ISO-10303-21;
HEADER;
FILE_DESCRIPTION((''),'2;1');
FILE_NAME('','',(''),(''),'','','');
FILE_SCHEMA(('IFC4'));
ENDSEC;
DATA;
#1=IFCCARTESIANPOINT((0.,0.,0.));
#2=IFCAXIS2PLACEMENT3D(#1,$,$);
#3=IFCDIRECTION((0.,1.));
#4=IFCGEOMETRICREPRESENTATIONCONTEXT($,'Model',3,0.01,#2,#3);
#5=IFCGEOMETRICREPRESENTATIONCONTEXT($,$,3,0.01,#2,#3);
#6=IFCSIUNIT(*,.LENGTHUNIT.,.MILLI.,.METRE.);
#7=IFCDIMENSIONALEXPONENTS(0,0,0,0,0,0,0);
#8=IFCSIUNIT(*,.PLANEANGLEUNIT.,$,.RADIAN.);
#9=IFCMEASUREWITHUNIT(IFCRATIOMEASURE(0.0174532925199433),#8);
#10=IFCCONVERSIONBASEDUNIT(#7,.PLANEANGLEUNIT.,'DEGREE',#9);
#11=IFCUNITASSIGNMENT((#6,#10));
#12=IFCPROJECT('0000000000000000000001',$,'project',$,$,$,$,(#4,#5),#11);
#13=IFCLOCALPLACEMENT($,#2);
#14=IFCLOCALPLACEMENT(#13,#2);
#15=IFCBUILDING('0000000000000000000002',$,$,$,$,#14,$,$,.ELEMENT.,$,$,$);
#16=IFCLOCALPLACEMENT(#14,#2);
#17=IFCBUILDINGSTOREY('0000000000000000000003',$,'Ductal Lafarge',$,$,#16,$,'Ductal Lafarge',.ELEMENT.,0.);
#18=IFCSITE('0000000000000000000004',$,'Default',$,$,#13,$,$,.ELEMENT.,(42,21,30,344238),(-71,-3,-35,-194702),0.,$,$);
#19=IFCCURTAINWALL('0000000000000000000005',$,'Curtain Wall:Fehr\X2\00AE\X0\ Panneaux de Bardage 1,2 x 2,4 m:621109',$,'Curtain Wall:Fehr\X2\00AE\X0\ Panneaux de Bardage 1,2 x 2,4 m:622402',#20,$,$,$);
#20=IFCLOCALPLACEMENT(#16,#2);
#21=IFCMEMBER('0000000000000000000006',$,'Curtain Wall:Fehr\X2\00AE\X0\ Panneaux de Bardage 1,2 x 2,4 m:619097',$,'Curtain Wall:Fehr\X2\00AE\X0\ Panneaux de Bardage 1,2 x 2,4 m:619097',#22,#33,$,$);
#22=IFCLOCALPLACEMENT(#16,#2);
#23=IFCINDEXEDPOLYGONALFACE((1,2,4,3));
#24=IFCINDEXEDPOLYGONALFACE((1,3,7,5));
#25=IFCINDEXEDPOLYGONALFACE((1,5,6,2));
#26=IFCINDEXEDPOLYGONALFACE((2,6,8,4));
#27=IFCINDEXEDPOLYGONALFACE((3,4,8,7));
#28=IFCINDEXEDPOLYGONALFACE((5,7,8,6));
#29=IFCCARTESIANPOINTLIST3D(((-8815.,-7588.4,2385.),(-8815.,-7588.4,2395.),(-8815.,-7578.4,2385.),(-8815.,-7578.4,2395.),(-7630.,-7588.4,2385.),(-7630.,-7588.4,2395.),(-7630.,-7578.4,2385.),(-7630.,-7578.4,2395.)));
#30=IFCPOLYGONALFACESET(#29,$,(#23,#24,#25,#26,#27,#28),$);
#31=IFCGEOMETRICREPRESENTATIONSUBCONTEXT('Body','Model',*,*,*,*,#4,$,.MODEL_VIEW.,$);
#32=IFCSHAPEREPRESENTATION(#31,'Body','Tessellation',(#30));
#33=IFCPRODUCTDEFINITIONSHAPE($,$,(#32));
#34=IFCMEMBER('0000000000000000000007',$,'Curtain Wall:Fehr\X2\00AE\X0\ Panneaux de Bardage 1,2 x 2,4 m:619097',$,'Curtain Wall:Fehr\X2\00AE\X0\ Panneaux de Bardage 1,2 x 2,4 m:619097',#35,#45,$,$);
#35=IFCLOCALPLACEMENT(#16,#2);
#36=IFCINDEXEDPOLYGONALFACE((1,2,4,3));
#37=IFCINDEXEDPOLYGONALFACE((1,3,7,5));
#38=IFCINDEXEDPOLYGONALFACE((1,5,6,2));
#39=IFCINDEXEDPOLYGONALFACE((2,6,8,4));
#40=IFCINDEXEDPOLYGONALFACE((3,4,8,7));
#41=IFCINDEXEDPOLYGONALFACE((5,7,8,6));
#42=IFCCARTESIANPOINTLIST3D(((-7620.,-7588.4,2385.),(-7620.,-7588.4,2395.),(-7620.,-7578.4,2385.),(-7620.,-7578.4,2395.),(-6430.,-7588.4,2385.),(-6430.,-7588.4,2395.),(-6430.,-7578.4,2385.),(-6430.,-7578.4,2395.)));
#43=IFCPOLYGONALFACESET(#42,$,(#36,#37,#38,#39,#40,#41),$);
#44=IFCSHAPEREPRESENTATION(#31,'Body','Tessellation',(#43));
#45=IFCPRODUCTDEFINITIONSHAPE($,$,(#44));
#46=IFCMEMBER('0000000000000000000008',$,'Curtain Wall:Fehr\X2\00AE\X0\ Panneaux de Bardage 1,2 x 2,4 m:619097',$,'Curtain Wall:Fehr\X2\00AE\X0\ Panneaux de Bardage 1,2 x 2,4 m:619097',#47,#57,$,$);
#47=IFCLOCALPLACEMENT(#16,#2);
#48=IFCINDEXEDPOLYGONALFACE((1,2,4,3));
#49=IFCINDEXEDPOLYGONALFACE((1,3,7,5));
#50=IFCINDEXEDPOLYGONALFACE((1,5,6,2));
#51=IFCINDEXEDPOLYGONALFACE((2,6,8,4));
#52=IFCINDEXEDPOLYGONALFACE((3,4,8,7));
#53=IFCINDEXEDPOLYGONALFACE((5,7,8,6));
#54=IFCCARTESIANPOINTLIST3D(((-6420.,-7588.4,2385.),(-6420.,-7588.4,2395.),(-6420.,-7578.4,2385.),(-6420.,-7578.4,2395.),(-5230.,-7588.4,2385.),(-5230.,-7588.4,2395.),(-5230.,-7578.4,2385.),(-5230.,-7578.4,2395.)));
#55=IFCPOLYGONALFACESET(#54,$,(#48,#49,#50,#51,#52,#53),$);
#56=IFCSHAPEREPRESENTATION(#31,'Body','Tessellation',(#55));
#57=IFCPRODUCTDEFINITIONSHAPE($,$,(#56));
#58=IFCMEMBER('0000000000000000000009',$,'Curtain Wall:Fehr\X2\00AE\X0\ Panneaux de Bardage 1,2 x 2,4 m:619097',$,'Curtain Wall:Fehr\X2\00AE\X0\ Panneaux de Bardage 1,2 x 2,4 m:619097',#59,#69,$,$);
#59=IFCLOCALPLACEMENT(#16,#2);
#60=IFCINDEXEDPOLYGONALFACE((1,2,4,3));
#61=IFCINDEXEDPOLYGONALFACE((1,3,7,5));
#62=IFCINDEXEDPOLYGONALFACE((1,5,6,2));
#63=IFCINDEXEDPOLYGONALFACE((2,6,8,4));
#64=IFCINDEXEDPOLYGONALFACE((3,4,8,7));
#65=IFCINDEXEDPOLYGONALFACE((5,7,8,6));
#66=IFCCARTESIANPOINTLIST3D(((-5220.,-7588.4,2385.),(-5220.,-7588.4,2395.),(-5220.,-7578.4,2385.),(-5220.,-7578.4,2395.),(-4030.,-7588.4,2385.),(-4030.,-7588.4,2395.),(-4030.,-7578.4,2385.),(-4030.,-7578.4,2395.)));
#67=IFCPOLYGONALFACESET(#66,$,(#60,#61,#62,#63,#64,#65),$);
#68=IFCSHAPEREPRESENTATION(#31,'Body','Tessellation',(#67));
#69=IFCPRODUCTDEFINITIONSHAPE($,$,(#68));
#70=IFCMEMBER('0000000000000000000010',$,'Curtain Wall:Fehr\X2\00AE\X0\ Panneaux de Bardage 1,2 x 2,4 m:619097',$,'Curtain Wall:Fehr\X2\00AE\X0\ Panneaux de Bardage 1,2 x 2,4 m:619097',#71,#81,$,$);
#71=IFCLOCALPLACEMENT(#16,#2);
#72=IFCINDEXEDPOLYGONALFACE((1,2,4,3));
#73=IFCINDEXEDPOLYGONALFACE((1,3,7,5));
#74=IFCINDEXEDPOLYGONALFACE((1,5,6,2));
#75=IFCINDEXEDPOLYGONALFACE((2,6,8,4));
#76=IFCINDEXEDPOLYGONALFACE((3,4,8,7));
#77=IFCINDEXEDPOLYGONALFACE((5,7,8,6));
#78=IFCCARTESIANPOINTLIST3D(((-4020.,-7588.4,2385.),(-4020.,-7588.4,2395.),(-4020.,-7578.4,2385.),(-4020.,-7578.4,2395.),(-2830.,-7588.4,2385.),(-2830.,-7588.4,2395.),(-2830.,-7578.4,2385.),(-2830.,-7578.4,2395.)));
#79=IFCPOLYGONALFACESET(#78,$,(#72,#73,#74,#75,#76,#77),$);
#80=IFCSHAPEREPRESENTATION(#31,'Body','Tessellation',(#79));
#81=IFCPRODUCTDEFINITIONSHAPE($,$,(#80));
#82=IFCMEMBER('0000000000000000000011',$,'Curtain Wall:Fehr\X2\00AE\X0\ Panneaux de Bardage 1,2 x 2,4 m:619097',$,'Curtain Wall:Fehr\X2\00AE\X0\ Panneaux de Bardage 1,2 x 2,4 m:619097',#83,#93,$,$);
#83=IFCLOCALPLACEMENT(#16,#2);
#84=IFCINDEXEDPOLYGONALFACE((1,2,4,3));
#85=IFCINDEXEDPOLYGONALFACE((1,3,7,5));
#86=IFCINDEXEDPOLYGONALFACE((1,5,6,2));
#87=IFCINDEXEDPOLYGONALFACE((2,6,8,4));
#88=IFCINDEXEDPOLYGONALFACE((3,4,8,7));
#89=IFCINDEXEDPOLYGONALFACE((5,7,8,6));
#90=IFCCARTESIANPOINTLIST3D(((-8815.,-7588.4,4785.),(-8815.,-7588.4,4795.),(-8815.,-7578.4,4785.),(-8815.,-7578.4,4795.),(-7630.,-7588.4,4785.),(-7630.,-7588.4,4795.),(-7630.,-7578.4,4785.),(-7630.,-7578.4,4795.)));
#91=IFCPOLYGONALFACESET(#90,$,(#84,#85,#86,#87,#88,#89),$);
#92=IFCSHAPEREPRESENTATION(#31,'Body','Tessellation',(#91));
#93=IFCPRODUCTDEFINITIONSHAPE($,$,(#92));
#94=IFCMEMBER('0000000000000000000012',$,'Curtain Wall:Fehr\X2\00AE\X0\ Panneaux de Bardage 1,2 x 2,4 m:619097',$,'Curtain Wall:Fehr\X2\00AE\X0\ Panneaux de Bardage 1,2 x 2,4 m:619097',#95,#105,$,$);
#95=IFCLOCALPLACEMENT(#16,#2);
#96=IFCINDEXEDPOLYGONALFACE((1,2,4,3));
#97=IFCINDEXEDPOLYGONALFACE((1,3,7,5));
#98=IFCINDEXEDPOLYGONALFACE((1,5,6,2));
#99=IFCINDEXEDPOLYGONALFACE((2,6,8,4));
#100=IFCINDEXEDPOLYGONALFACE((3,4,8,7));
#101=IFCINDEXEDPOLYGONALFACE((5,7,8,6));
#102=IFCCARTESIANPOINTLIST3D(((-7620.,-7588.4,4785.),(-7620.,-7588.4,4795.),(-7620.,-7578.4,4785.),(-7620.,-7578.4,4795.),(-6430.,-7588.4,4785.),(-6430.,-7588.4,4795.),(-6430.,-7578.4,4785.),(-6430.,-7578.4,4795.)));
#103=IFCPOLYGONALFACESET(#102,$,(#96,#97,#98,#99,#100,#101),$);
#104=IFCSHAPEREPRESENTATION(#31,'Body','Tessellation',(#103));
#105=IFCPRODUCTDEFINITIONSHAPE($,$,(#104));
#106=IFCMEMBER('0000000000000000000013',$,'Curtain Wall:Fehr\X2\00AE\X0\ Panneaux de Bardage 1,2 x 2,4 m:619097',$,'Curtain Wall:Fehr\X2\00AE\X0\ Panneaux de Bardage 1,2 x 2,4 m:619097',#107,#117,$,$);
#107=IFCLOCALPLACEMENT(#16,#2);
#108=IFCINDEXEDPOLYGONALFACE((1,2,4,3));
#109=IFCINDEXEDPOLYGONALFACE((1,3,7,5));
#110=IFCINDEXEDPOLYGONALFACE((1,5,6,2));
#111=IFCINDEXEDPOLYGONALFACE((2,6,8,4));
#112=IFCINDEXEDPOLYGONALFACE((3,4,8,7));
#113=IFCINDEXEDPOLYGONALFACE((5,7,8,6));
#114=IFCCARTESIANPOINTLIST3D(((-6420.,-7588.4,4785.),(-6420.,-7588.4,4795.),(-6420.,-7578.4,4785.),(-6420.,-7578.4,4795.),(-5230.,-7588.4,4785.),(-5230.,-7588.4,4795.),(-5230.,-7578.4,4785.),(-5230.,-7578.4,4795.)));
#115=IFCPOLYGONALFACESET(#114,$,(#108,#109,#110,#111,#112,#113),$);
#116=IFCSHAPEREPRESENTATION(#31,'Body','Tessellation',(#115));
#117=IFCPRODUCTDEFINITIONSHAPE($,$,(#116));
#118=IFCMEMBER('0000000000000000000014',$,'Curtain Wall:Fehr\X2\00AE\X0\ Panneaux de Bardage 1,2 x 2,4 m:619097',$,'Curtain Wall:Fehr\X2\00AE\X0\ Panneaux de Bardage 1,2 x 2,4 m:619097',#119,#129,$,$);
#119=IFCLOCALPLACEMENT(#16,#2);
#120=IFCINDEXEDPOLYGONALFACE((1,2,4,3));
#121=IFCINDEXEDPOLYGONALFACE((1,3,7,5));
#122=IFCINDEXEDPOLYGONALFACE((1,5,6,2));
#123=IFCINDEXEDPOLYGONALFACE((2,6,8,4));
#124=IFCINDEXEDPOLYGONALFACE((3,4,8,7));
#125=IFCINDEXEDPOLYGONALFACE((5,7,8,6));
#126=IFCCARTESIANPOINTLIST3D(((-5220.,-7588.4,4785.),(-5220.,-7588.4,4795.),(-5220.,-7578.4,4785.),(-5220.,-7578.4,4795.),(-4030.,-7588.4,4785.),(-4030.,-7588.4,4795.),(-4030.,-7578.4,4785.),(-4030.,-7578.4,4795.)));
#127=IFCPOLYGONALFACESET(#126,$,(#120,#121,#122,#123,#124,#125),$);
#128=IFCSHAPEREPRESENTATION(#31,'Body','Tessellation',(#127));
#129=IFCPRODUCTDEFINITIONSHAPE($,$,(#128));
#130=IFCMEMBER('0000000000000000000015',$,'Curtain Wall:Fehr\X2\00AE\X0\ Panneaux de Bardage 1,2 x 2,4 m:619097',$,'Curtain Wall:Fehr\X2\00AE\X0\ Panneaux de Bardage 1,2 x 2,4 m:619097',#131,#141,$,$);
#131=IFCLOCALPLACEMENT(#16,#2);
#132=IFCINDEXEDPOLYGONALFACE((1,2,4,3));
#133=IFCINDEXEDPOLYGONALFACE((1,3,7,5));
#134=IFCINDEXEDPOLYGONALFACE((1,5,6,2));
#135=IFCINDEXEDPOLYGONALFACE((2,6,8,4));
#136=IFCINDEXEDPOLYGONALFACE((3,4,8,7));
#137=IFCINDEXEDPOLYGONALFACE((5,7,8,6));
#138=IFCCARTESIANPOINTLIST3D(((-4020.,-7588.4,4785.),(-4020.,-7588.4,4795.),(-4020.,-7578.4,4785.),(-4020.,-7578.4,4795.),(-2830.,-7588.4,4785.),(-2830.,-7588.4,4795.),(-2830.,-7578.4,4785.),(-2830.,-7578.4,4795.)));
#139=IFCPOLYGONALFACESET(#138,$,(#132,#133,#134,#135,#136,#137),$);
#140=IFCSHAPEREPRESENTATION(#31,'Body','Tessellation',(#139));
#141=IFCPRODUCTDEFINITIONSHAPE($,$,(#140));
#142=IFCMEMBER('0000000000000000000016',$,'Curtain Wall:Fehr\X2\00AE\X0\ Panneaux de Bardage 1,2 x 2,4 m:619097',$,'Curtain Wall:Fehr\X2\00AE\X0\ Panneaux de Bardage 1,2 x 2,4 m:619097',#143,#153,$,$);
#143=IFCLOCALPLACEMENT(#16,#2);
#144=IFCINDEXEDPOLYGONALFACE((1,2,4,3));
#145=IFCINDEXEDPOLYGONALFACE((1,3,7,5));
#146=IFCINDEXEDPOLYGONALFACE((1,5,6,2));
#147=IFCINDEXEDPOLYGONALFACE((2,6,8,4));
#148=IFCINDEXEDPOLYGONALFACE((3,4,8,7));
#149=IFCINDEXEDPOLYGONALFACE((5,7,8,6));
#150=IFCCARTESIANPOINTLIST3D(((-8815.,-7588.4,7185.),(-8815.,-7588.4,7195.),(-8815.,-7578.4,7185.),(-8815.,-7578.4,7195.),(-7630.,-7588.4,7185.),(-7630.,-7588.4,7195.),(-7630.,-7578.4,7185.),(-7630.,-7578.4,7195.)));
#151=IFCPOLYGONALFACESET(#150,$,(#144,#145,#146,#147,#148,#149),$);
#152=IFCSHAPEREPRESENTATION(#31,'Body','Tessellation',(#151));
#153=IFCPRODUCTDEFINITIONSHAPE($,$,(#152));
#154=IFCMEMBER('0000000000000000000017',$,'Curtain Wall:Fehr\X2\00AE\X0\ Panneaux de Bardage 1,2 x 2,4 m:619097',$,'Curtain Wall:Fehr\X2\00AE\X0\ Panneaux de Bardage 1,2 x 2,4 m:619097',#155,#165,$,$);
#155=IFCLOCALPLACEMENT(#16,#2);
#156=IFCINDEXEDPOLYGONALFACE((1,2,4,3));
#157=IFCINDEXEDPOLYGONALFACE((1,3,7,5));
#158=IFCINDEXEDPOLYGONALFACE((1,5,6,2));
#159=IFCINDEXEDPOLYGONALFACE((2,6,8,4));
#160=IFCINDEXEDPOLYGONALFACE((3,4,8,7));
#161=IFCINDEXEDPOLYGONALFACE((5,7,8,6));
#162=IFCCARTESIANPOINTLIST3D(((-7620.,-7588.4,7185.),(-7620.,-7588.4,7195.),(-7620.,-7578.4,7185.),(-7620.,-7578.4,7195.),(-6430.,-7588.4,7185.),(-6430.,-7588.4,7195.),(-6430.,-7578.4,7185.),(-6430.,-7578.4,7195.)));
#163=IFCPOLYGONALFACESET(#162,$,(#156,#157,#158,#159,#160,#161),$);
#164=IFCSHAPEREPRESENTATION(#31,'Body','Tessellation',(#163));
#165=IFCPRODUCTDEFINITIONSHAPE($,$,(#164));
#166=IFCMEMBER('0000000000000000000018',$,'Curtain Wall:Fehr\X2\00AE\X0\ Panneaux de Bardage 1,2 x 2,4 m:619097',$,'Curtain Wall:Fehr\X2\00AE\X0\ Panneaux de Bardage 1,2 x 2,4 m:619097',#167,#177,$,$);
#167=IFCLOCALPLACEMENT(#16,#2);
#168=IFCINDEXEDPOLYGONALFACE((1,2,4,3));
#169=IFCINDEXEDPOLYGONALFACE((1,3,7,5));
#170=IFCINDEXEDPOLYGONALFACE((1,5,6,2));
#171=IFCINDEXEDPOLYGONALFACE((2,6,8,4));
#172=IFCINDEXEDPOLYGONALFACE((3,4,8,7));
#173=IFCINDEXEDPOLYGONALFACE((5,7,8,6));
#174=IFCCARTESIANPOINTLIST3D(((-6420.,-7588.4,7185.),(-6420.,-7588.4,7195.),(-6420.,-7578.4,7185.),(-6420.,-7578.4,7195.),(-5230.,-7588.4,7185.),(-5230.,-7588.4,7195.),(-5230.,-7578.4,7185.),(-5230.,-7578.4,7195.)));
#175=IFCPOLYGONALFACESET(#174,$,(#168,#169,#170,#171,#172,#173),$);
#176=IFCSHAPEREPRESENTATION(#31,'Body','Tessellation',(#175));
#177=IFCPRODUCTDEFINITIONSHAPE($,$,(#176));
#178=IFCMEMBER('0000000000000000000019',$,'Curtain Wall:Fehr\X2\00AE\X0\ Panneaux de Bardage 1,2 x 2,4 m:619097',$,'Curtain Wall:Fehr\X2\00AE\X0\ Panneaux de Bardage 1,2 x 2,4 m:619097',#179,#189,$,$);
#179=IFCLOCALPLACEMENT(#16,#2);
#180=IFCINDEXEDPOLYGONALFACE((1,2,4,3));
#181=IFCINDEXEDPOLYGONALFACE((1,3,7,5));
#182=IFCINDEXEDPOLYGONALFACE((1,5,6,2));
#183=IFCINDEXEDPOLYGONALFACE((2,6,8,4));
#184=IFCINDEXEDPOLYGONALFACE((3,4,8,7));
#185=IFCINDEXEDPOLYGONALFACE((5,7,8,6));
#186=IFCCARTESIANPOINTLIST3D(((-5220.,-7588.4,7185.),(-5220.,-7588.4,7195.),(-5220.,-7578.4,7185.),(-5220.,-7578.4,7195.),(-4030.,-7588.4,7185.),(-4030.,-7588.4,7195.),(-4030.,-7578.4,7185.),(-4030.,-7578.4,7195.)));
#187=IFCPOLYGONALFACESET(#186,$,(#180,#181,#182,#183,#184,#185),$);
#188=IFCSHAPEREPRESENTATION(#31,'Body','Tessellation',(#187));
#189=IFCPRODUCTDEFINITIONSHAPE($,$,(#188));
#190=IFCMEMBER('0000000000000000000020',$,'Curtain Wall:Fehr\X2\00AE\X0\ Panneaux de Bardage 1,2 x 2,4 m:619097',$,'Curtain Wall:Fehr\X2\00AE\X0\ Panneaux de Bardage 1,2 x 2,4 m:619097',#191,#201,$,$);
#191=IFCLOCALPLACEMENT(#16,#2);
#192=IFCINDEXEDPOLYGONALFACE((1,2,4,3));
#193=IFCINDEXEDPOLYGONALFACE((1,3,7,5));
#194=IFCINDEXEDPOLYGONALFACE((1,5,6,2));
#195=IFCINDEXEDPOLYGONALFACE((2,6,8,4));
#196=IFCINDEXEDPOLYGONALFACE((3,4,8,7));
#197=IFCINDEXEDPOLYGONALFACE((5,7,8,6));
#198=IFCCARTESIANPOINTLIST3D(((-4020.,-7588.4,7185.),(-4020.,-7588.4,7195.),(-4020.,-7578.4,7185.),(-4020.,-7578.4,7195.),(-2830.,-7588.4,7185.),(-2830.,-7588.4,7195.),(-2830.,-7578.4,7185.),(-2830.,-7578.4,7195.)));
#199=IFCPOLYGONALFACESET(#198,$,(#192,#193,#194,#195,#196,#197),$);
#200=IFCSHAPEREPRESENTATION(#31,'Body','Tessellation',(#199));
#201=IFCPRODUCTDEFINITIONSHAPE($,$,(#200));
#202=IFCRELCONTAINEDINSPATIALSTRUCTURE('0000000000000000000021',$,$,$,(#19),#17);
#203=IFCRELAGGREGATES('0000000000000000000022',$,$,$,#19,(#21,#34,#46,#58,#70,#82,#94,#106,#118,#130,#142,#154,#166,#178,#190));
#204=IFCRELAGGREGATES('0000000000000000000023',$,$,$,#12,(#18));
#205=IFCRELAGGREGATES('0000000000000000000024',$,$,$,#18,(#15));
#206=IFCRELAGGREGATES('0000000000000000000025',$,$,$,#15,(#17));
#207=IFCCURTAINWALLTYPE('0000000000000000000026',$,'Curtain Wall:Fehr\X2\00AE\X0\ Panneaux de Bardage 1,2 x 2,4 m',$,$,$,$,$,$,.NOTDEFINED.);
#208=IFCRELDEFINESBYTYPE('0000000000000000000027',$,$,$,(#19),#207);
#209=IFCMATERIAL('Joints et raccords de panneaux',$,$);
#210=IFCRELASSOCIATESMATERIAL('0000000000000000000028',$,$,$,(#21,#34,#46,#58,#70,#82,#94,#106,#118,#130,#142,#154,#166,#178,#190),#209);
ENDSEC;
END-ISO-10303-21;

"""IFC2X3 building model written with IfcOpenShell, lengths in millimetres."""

from ifc_helpers import new_model, entity, si_unit, converted_unit, direction, frame, frame_2d, origin, origin_2d_with_axis, place, context, subcontext, project, spatial, rectangle, extrude, material, type_object, element, aggregate, save


model = new_model("IFC2X3")

# Units and contexts
model_context = context("Model", 3, precision=0.01, world=origin(), true_north=direction((0.0, 1.0)))
context_of_model = context(None, 3, precision=0.01, world=origin(), true_north=direction((0.0, 1.0)))
body_context = subcontext(model_context, "Body", "Model", "MODEL_VIEW")
ifc_project = project(units=[si_unit("LENGTHUNIT", "METRE", prefix="MILLI"), converted_unit("PLANEANGLEUNIT", "DEGREE", entity("IfcRatioMeasure", 0.0174532925199433), si_unit("PLANEANGLEUNIT", "RADIAN"), dimensions=[0, 0, 0, 0, 0, 0, 0])], contexts=[model_context, context_of_model])

# Site, building, storey
site_placement = place(None, origin())
site = spatial("IfcSite", under=ifc_project, at=site_placement, Name="Default", CompositionType="ELEMENT", RefLatitude=(42, 21, 30, 344238), RefLongitude=(-71, -3, -35, -194702), RefElevation=0.0)
building_placement = place(site_placement, origin())
building = spatial("IfcBuilding", under=site, at=building_placement, CompositionType="ELEMENT")
storey_placement = place(building_placement, origin())
storey = spatial("IfcBuildingStorey", under=building, at=storey_placement, Name="Ductal Lafarge", LongName="Ductal Lafarge", CompositionType="ELEMENT", Elevation=0.0)

# Curtain wall, members
curtain_wall_type = type_object("IfcCurtainWallType", Name="Curtain Wall:Fehr® Panneaux de Bardage 1,2 x 2,4 m", PredefinedType="NOTDEFINED")
curtain_wall_placement = place(storey_placement, origin())
curtain_wall = element("IfcCurtainWall", 1, at=curtain_wall_placement, inside=storey, type_object=curtain_wall_type, Name="Curtain Wall:Fehr® Panneaux de Bardage 1,2 x 2,4 m:621109", ObjectType="Curtain Wall:Fehr® Panneaux de Bardage 1,2 x 2,4 m:622402")
ifc_material = material(Name="Joints et raccords de panneaux")
member_1_placement = place(curtain_wall_placement, frame((-8815.0, -7588.4, 2385.0)))
member_1 = element("IfcMember", 2, at=member_1_placement, material=ifc_material, Name="Curtain Wall:Fehr® Panneaux de Bardage 1,2 x 2,4 m:619097", ObjectType="Curtain Wall:Fehr® Panneaux de Bardage 1,2 x 2,4 m:619097", context=body_context, shape_type="SweptSolid", body=[
    extrude(rectangle(XDim=1185.0, YDim=10.0, at=frame_2d((0.0, 0.0), x_axis=(1.0, 0.0))), frame((592.5, 5.0, 0.0), z_axis=(0.0, 0.0, 1.0), x_axis=(-1.0, 0.0, 0.0)), (0.0, 0.0, 1.0), 10.0),
])
member_2_placement = place(curtain_wall_placement, frame((-7620.0, -7588.4, 2385.0)))
member_2 = element("IfcMember", 3, at=member_2_placement, material=ifc_material, Name="Curtain Wall:Fehr® Panneaux de Bardage 1,2 x 2,4 m:619097", ObjectType="Curtain Wall:Fehr® Panneaux de Bardage 1,2 x 2,4 m:619097", context=body_context, shape_type="SweptSolid", body=[
    extrude(rectangle(XDim=1190.0, YDim=10.0, at=frame_2d((0.0, 0.0), x_axis=(1.0, 0.0))), frame((595.0, 5.0, 0.0), z_axis=(0.0, 0.0, 1.0), x_axis=(-1.0, 0.0, 0.0)), (0.0, 0.0, 1.0), 10.0),
])
member_3_placement = place(curtain_wall_placement, frame((-6420.0, -7588.4, 2385.0)))
member_3 = element("IfcMember", 4, at=member_3_placement, material=ifc_material, Name="Curtain Wall:Fehr® Panneaux de Bardage 1,2 x 2,4 m:619097", ObjectType="Curtain Wall:Fehr® Panneaux de Bardage 1,2 x 2,4 m:619097", context=body_context, shape_type="SweptSolid", body=[
    extrude(rectangle(XDim=1190.0, YDim=10.0, at=origin_2d_with_axis()), frame((595.0, 5.0, 0.0), z_axis=(0.0, 0.0, 1.0), x_axis=(-1.0, 0.0, 0.0)), (0.0, 0.0, 1.0), 10.0),
])
member_4_placement = place(curtain_wall_placement, frame((-5220.0, -7588.4, 2385.0)))
member_4 = element("IfcMember", 5, at=member_4_placement, material=ifc_material, Name="Curtain Wall:Fehr® Panneaux de Bardage 1,2 x 2,4 m:619097", ObjectType="Curtain Wall:Fehr® Panneaux de Bardage 1,2 x 2,4 m:619097", context=body_context, shape_type="SweptSolid", body=[
    extrude(rectangle(XDim=1190.0, YDim=10.0, at=origin_2d_with_axis()), frame((595.0, 5.0, 0.0), z_axis=(0.0, 0.0, 1.0), x_axis=(-1.0, 0.0, 0.0)), (0.0, 0.0, 1.0), 10.0),
])
member_5_placement = place(curtain_wall_placement, frame((-4020.0, -7588.4, 2385.0)))
member_5 = element("IfcMember", 6, at=member_5_placement, material=ifc_material, Name="Curtain Wall:Fehr® Panneaux de Bardage 1,2 x 2,4 m:619097", ObjectType="Curtain Wall:Fehr® Panneaux de Bardage 1,2 x 2,4 m:619097", context=body_context, shape_type="SweptSolid", body=[
    extrude(rectangle(XDim=1190.0, YDim=10.0, at=origin_2d_with_axis()), frame((595.0, 5.0, 0.0), z_axis=(0.0, 0.0, 1.0), x_axis=(-1.0, 0.0, 0.0)), (0.0, 0.0, 1.0), 10.0),
])
member_6_placement = place(curtain_wall_placement, frame((-8815.0, -7588.4, 4785.0)))
member_6 = element("IfcMember", 7, at=member_6_placement, material=ifc_material, Name="Curtain Wall:Fehr® Panneaux de Bardage 1,2 x 2,4 m:619097", ObjectType="Curtain Wall:Fehr® Panneaux de Bardage 1,2 x 2,4 m:619097", context=body_context, shape_type="SweptSolid", body=[
    extrude(rectangle(XDim=1185.0, YDim=10.0, at=frame_2d((0.0, 0.0), x_axis=(1.0, 0.0))), frame((592.5, 5.0, 0.0), z_axis=(0.0, 0.0, 1.0), x_axis=(-1.0, 0.0, 0.0)), (0.0, 0.0, 1.0), 10.0),
])
member_7_placement = place(curtain_wall_placement, frame((-7620.0, -7588.4, 4785.0)))
member_7 = element("IfcMember", 8, at=member_7_placement, material=ifc_material, Name="Curtain Wall:Fehr® Panneaux de Bardage 1,2 x 2,4 m:619097", ObjectType="Curtain Wall:Fehr® Panneaux de Bardage 1,2 x 2,4 m:619097", context=body_context, shape_type="SweptSolid", body=[
    extrude(rectangle(XDim=1190.0, YDim=10.0, at=frame_2d((0.0, 0.0), x_axis=(1.0, 0.0))), frame((595.0, 5.0, 0.0), z_axis=(0.0, 0.0, 1.0), x_axis=(-1.0, 0.0, 0.0)), (0.0, 0.0, 1.0), 10.0),
])
member_8_placement = place(curtain_wall_placement, frame((-6420.0, -7588.4, 4785.0)))
member_8 = element("IfcMember", 9, at=member_8_placement, material=ifc_material, Name="Curtain Wall:Fehr® Panneaux de Bardage 1,2 x 2,4 m:619097", ObjectType="Curtain Wall:Fehr® Panneaux de Bardage 1,2 x 2,4 m:619097", context=body_context, shape_type="SweptSolid", body=[
    extrude(rectangle(XDim=1190.0, YDim=10.0, at=origin_2d_with_axis()), frame((595.0, 5.0, 0.0), z_axis=(0.0, 0.0, 1.0), x_axis=(-1.0, 0.0, 0.0)), (0.0, 0.0, 1.0), 10.0),
])
member_9_placement = place(curtain_wall_placement, frame((-5220.0, -7588.4, 4785.0)))
member_9 = element("IfcMember", 10, at=member_9_placement, material=ifc_material, Name="Curtain Wall:Fehr® Panneaux de Bardage 1,2 x 2,4 m:619097", ObjectType="Curtain Wall:Fehr® Panneaux de Bardage 1,2 x 2,4 m:619097", context=body_context, shape_type="SweptSolid", body=[
    extrude(rectangle(XDim=1190.0, YDim=10.0, at=origin_2d_with_axis()), frame((595.0, 5.0, 0.0), z_axis=(0.0, 0.0, 1.0), x_axis=(-1.0, 0.0, 0.0)), (0.0, 0.0, 1.0), 10.0),
])
member_10_placement = place(curtain_wall_placement, frame((-4020.0, -7588.4, 4785.0)))
member_10 = element("IfcMember", 11, at=member_10_placement, material=ifc_material, Name="Curtain Wall:Fehr® Panneaux de Bardage 1,2 x 2,4 m:619097", ObjectType="Curtain Wall:Fehr® Panneaux de Bardage 1,2 x 2,4 m:619097", context=body_context, shape_type="SweptSolid", body=[
    extrude(rectangle(XDim=1190.0, YDim=10.0, at=origin_2d_with_axis()), frame((595.0, 5.0, 0.0), z_axis=(0.0, 0.0, 1.0), x_axis=(-1.0, 0.0, 0.0)), (0.0, 0.0, 1.0), 10.0),
])
member_11_placement = place(curtain_wall_placement, frame((-8815.0, -7588.4, 7185.0)))
member_11 = element("IfcMember", 12, at=member_11_placement, material=ifc_material, Name="Curtain Wall:Fehr® Panneaux de Bardage 1,2 x 2,4 m:619097", ObjectType="Curtain Wall:Fehr® Panneaux de Bardage 1,2 x 2,4 m:619097", context=body_context, shape_type="SweptSolid", body=[
    extrude(rectangle(XDim=1185.0, YDim=10.0, at=frame_2d((0.0, 0.0), x_axis=(1.0, 0.0))), frame((592.5, 5.0, 0.0), z_axis=(0.0, 0.0, 1.0), x_axis=(-1.0, 0.0, 0.0)), (0.0, 0.0, 1.0), 10.0),
])
member_12_placement = place(curtain_wall_placement, frame((-7620.0, -7588.4, 7185.0)))
member_12 = element("IfcMember", 13, at=member_12_placement, material=ifc_material, Name="Curtain Wall:Fehr® Panneaux de Bardage 1,2 x 2,4 m:619097", ObjectType="Curtain Wall:Fehr® Panneaux de Bardage 1,2 x 2,4 m:619097", context=body_context, shape_type="SweptSolid", body=[
    extrude(rectangle(XDim=1190.0, YDim=10.0, at=frame_2d((0.0, 0.0), x_axis=(1.0, 0.0))), frame((595.0, 5.0, 0.0), z_axis=(0.0, 0.0, 1.0), x_axis=(-1.0, 0.0, 0.0)), (0.0, 0.0, 1.0), 10.0),
])
member_13_placement = place(curtain_wall_placement, frame((-6420.0, -7588.4, 7185.0)))
member_13 = element("IfcMember", 14, at=member_13_placement, material=ifc_material, Name="Curtain Wall:Fehr® Panneaux de Bardage 1,2 x 2,4 m:619097", ObjectType="Curtain Wall:Fehr® Panneaux de Bardage 1,2 x 2,4 m:619097", context=body_context, shape_type="SweptSolid", body=[
    extrude(rectangle(XDim=1190.0, YDim=10.0, at=origin_2d_with_axis()), frame((595.0, 5.0, 0.0), z_axis=(0.0, 0.0, 1.0), x_axis=(-1.0, 0.0, 0.0)), (0.0, 0.0, 1.0), 10.0),
])
member_14_placement = place(curtain_wall_placement, frame((-5220.0, -7588.4, 7185.0)))
member_14 = element("IfcMember", 15, at=member_14_placement, material=ifc_material, Name="Curtain Wall:Fehr® Panneaux de Bardage 1,2 x 2,4 m:619097", ObjectType="Curtain Wall:Fehr® Panneaux de Bardage 1,2 x 2,4 m:619097", context=body_context, shape_type="SweptSolid", body=[
    extrude(rectangle(XDim=1190.0, YDim=10.0, at=origin_2d_with_axis()), frame((595.0, 5.0, 0.0), z_axis=(0.0, 0.0, 1.0), x_axis=(-1.0, 0.0, 0.0)), (0.0, 0.0, 1.0), 10.0),
])
member_15_placement = place(curtain_wall_placement, frame((-4020.0, -7588.4, 7185.0)))
member_15 = element("IfcMember", 16, at=member_15_placement, material=ifc_material, Name="Curtain Wall:Fehr® Panneaux de Bardage 1,2 x 2,4 m:619097", ObjectType="Curtain Wall:Fehr® Panneaux de Bardage 1,2 x 2,4 m:619097", context=body_context, shape_type="SweptSolid", body=[
    extrude(rectangle(XDim=1190.0, YDim=10.0, at=origin_2d_with_axis()), frame((595.0, 5.0, 0.0), z_axis=(0.0, 0.0, 1.0), x_axis=(-1.0, 0.0, 0.0)), (0.0, 0.0, 1.0), 10.0),
])
aggregate(curtain_wall, [member_1, member_2, member_3, member_4, member_5, member_6, member_7, member_8, member_9, member_10, member_11, member_12, member_13, member_14, member_15])

save(model, "model.ifc")
